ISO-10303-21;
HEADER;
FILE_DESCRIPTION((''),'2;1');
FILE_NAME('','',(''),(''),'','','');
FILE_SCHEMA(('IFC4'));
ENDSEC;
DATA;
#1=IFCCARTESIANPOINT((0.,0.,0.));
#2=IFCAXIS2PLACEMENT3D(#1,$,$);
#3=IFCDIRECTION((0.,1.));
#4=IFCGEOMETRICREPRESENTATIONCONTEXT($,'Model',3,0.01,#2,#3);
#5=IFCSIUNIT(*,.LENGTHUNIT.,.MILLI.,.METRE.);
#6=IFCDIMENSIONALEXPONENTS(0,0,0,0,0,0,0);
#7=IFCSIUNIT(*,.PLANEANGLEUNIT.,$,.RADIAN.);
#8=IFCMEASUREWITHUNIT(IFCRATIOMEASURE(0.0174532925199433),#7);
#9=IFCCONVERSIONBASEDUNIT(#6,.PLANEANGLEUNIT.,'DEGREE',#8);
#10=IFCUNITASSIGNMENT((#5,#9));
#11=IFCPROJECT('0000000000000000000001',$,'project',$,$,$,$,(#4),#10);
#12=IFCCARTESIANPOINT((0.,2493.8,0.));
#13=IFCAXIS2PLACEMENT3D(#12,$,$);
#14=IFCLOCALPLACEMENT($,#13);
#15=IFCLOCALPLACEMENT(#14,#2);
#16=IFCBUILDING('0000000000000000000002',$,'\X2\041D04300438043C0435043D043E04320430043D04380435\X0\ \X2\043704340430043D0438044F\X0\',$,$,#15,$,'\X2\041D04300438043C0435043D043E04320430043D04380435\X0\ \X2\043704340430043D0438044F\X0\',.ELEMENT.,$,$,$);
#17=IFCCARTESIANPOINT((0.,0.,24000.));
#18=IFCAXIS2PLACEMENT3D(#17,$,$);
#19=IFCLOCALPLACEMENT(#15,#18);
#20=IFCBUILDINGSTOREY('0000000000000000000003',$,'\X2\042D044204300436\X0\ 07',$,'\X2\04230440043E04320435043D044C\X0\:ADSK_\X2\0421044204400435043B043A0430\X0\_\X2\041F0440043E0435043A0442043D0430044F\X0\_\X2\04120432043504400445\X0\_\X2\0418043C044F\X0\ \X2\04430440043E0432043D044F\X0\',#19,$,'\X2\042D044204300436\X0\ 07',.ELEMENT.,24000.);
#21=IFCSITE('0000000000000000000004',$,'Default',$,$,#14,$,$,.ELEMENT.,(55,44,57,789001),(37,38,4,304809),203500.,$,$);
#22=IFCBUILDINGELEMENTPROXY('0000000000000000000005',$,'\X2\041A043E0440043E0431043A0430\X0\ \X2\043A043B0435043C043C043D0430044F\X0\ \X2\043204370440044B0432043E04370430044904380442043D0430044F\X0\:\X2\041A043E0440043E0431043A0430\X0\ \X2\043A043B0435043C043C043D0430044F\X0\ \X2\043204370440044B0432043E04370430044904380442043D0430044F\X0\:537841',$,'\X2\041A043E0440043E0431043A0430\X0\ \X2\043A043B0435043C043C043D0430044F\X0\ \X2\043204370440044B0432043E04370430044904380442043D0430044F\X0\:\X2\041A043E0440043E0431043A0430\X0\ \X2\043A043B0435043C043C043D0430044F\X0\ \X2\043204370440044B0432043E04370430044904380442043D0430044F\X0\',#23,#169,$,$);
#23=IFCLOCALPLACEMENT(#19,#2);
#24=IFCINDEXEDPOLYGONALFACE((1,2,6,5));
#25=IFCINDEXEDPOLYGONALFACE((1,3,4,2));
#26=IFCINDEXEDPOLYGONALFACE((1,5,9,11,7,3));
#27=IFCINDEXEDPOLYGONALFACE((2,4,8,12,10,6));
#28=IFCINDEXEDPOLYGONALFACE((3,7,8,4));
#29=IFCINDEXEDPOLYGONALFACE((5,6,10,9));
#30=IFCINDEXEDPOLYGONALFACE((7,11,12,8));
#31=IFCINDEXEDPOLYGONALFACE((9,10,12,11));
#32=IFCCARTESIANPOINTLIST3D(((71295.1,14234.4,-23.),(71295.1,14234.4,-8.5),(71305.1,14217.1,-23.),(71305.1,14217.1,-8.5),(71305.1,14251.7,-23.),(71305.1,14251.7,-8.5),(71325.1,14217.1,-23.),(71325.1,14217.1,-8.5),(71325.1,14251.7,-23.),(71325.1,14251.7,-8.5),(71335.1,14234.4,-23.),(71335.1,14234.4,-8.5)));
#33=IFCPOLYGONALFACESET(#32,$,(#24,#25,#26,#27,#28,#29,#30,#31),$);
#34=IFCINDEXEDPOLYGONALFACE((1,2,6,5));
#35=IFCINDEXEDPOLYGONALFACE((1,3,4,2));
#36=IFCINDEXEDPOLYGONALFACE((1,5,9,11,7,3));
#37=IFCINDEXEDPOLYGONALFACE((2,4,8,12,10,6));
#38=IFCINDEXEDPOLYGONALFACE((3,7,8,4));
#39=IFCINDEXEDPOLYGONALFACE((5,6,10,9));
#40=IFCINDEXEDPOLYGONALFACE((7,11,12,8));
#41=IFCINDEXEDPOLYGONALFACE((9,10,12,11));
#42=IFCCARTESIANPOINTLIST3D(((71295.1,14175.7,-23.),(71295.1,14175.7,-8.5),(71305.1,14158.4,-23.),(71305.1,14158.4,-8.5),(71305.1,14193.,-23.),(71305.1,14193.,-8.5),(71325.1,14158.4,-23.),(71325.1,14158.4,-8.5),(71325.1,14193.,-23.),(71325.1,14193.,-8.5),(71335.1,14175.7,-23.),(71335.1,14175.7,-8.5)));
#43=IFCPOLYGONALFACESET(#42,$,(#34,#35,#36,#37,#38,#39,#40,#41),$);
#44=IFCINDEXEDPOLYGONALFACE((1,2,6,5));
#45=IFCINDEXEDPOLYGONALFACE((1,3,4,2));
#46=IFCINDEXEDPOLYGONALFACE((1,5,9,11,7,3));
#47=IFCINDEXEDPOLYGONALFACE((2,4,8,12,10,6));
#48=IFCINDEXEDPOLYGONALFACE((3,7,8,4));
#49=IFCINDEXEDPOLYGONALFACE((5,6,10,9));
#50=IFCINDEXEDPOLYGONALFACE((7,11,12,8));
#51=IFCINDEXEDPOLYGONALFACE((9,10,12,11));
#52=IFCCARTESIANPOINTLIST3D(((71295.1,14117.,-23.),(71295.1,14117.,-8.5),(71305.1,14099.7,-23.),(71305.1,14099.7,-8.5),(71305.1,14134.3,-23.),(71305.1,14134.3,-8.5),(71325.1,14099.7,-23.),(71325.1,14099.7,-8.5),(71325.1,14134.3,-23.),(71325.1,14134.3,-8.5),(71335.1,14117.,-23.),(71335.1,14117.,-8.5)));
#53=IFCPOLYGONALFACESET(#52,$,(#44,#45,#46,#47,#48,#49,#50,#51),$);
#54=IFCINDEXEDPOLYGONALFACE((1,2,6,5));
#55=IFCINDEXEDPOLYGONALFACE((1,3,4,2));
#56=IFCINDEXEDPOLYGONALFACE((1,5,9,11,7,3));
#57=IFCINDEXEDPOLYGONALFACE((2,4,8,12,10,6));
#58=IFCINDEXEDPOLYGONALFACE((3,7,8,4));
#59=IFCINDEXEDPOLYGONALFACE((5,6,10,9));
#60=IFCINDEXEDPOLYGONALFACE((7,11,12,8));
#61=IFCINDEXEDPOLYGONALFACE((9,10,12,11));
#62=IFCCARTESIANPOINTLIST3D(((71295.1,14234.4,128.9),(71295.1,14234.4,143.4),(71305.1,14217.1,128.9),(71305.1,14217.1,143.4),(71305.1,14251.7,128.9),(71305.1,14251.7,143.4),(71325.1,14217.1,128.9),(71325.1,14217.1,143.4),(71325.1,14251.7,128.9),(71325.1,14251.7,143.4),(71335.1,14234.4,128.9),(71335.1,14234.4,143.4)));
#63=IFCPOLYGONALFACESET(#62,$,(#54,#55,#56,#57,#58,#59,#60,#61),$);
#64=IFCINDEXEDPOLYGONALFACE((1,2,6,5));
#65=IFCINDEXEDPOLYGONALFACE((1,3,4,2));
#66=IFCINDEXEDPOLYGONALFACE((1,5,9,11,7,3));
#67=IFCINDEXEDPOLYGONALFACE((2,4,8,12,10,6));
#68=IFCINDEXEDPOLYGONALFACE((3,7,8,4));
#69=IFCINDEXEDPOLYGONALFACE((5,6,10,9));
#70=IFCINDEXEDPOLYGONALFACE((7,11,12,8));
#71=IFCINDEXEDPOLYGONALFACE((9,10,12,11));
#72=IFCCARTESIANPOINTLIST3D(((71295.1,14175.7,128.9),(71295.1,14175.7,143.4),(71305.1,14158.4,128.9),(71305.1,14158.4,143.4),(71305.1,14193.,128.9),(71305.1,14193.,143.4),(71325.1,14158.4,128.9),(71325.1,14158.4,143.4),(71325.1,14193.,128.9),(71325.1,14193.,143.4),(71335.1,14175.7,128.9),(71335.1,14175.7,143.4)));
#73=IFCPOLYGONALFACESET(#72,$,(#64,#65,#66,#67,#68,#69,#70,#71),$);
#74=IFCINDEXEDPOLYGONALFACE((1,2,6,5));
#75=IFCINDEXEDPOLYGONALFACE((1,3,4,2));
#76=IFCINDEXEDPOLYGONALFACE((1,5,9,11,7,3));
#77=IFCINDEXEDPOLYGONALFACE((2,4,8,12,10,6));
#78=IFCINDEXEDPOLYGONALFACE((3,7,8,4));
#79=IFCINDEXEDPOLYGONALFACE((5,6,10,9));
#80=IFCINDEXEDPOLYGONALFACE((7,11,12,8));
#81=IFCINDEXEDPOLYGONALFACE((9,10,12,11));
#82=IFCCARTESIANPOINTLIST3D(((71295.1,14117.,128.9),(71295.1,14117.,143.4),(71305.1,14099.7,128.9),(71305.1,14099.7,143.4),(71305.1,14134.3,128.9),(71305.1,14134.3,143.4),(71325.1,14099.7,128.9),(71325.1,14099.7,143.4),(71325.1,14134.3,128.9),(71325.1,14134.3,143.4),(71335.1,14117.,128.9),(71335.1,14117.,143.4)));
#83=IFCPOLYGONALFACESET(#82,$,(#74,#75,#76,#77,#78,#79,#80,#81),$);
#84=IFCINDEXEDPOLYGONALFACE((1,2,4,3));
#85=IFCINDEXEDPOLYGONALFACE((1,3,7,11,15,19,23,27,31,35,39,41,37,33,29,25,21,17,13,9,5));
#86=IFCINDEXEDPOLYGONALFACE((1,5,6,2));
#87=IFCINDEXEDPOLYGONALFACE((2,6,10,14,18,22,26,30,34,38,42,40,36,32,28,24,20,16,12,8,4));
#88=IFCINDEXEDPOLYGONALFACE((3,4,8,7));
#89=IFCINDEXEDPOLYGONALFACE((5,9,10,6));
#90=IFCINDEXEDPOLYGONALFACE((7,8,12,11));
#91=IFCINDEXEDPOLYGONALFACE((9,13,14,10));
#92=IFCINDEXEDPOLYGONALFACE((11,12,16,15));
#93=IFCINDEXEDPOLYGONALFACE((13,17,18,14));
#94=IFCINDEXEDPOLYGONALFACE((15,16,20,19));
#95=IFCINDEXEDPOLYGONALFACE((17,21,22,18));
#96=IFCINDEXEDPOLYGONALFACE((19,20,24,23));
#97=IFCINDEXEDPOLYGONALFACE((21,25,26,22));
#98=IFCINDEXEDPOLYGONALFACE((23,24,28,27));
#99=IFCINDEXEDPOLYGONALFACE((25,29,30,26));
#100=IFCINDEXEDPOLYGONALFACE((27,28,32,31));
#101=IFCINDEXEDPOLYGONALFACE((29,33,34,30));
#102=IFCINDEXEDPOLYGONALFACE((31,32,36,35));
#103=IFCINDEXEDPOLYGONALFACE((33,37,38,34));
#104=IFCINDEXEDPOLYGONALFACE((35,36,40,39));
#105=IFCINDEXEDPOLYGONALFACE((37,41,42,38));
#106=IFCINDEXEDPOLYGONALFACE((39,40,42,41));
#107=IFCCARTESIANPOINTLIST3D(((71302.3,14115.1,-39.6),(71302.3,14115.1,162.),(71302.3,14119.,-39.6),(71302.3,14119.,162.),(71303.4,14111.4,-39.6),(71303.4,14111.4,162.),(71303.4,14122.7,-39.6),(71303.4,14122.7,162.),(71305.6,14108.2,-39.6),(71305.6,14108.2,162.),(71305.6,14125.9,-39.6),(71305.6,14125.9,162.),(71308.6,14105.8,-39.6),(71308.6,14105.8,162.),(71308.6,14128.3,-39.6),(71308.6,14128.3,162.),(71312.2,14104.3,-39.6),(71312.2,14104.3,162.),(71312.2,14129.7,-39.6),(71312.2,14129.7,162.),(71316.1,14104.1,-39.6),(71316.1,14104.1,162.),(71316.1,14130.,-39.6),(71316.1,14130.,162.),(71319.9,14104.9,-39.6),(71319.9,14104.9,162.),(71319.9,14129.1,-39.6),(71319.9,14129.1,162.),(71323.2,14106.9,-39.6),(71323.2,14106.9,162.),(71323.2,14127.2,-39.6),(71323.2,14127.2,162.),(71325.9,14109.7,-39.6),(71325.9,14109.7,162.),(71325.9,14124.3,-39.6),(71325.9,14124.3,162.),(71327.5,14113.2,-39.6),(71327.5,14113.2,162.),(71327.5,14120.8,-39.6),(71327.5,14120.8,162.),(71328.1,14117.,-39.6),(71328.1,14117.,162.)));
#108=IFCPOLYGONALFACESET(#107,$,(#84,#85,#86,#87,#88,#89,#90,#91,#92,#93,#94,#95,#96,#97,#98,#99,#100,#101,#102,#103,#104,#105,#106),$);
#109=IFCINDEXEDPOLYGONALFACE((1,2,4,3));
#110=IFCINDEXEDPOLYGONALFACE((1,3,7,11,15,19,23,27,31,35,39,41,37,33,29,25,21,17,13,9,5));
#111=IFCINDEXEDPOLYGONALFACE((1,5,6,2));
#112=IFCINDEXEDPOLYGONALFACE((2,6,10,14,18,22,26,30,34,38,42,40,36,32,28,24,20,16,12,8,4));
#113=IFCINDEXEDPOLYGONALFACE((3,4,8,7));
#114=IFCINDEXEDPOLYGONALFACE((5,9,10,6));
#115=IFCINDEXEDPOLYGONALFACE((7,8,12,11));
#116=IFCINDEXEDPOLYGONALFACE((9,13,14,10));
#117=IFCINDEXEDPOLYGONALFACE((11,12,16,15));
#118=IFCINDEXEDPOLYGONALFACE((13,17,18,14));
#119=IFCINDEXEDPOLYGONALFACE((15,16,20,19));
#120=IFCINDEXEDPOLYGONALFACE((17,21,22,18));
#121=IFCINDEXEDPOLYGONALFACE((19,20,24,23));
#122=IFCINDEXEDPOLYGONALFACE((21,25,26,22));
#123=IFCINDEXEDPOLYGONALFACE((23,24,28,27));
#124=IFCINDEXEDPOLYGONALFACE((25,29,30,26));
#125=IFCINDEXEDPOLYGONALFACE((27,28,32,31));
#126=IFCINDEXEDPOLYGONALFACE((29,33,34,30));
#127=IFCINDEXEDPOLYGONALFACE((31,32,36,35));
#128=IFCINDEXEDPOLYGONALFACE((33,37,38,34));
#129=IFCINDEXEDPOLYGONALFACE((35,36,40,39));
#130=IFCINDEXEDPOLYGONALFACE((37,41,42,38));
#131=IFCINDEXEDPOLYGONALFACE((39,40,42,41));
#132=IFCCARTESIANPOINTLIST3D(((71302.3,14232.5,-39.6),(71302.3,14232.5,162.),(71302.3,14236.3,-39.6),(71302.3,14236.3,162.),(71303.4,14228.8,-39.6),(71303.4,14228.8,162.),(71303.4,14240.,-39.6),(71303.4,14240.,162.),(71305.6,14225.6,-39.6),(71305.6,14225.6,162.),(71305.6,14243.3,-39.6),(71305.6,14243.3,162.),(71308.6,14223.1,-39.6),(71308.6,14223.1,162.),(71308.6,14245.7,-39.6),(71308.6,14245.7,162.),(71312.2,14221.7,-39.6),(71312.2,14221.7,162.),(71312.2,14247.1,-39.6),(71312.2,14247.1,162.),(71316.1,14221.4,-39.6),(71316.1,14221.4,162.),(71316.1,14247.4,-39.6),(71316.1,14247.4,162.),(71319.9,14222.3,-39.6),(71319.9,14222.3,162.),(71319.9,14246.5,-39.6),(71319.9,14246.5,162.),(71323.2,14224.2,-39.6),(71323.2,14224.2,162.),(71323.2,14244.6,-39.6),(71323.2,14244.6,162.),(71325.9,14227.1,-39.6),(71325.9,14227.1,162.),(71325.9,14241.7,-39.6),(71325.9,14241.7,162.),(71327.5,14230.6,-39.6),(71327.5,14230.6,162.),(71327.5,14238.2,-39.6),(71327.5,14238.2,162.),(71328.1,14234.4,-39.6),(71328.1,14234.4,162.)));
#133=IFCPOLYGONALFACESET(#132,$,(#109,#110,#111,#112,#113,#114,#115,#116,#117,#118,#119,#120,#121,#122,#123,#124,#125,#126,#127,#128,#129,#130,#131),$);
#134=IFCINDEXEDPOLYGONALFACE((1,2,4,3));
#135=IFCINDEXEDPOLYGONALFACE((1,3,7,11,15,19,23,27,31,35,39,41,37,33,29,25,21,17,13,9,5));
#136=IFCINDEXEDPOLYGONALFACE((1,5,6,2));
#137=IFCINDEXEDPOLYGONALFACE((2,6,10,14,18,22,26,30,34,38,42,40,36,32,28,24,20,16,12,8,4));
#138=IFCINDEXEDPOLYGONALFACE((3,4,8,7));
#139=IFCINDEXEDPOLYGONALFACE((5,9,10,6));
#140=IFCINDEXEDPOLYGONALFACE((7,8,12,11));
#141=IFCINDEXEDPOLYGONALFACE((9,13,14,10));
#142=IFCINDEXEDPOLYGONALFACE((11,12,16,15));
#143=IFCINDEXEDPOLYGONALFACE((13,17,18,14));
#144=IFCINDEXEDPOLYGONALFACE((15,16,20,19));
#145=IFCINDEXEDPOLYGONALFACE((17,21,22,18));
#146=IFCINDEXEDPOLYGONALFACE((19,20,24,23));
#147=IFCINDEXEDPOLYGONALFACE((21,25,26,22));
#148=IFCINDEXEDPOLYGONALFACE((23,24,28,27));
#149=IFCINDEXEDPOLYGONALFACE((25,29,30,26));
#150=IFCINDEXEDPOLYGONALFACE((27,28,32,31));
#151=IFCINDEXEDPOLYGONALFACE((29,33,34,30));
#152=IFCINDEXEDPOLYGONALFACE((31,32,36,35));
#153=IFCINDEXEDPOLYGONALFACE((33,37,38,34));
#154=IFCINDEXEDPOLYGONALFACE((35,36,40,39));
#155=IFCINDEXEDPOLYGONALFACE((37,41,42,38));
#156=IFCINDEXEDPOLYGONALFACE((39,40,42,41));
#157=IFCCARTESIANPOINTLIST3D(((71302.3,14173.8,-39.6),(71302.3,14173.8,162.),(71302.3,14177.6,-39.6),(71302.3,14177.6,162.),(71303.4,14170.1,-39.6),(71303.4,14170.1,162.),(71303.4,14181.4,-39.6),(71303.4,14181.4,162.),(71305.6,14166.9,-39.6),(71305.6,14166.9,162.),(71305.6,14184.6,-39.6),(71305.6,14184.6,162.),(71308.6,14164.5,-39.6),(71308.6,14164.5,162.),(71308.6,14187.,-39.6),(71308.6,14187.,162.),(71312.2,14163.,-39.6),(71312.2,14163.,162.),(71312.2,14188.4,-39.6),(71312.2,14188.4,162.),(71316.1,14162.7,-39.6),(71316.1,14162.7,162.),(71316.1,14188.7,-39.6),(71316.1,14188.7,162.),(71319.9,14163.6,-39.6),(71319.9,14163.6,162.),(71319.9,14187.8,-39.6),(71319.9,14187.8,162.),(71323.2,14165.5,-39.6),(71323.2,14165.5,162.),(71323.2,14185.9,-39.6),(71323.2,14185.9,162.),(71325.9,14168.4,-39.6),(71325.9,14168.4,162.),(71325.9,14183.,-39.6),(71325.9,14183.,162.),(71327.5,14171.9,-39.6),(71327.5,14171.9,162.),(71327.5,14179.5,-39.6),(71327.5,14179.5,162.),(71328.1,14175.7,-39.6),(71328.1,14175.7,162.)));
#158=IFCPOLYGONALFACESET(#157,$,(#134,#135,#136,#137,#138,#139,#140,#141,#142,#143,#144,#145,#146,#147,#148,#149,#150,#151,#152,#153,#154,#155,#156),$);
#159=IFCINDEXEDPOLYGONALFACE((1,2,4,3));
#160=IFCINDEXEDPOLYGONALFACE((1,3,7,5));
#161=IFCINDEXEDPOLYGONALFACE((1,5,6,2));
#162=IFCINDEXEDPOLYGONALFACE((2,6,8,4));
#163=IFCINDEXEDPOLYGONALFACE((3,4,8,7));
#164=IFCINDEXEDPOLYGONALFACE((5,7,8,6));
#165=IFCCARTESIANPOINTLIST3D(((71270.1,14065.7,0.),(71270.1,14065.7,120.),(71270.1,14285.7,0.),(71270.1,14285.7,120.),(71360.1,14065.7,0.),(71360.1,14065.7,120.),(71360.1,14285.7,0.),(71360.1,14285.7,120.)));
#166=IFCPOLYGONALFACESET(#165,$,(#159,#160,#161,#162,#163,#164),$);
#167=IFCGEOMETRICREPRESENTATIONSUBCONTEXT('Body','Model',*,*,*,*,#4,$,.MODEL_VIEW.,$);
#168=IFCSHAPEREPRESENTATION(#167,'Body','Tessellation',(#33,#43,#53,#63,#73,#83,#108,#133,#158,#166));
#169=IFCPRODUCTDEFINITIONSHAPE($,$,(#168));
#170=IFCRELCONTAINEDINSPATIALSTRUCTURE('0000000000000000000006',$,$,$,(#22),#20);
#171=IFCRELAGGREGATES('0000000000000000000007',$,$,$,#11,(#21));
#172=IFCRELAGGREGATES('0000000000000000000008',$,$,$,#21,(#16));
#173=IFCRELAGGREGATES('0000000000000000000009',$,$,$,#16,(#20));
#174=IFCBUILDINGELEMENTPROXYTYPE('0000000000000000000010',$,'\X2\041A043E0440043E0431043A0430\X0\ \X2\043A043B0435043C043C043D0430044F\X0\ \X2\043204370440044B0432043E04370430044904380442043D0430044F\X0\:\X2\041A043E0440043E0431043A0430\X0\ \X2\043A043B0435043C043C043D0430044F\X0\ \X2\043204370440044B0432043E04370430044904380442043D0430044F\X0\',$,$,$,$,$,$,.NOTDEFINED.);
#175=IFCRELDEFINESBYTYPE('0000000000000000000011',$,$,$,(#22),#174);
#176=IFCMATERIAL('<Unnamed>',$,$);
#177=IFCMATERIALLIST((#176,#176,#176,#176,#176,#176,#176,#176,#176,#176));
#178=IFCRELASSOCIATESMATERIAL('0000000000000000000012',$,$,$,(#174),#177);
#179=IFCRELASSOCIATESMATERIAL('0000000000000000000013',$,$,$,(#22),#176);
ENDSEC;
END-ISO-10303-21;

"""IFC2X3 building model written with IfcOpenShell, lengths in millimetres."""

from ifc_helpers import new_model, entity, si_unit, converted_unit, direction, frame, frame_2d, origin, place, context, subcontext, project, spatial, polyline, rectangle, circle, outline, extrude, source, transform, mapped, material, material_list, type_object, type_shapes, element, save


model = new_model("IFC2X3")

# Units and contexts
model_context = context("Model", 3, precision=0.01, world=origin(), true_north=direction((0.0, 1.0)))
body_context = subcontext(model_context, "Body", "Model", "MODEL_VIEW")
ifc_project = project(units=[si_unit("LENGTHUNIT", "METRE", prefix="MILLI"), converted_unit("PLANEANGLEUNIT", "DEGREE", entity("IfcRatioMeasure", 0.0174532925199433), si_unit("PLANEANGLEUNIT", "RADIAN"), dimensions=[0, 0, 0, 0, 0, 0, 0])], contexts=[model_context])

# Site, building, storey
site_placement = place(None, frame((0.0, 2493.8, 0.0)))
site = spatial("IfcSite", under=ifc_project, at=site_placement, Name="Default", CompositionType="ELEMENT", RefLatitude=(55, 44, 57, 789001), RefLongitude=(37, 38, 4, 304809), RefElevation=203500.0)
building_placement = place(site_placement, origin())
building = spatial("IfcBuilding", under=site, at=building_placement, Name="Наименование здания", LongName="Наименование здания", CompositionType="ELEMENT")
storey_placement = place(building_placement, frame((0.0, 0.0, 24000.0)))
storey = spatial("IfcBuildingStorey", under=building, at=storey_placement, Name="Этаж 07", ObjectType="Уровень:ADSK_Стрелка_Проектная_Вверх_Имя уровня", LongName="Этаж 07", CompositionType="ELEMENT", Elevation=24000.0)

# Building element proxy
ifc_material = material(Name="<Unnamed>")
ifc_material_list = material_list([ifc_material, ifc_material, ifc_material, ifc_material, ifc_material, ifc_material, ifc_material, ifc_material, ifc_material, ifc_material])
building_element_proxy_type = type_object("IfcBuildingElementProxyType", Name="Коробка клеммная взрывозащитная:Коробка клеммная взрывозащитная", PredefinedType="NOTDEFINED", material=ifc_material_list)
shared_shape = source(origin(), body_context, "Body", "SweptSolid", [
    extrude(outline(polyline([(-10.0, -17.3), (10.0, -17.3), (20.0, 0.0), (10.0, 17.3), (-10.0, 17.3), (-20.0, 0.0), (-10.0, -17.3)])), frame((0.0, 58.7, -23.0), z_axis=(0.0, 0.0, 1.0), x_axis=(-1.0, 0.0, 0.0)), (0.0, 0.0, 1.0), 14.4),
    extrude(outline(polyline([(-10.0, -17.3), (10.0, -17.3), (20.0, 0.0), (10.0, 17.3), (-10.0, 17.3), (-20.0, 0.0), (-10.0, -17.3)])), frame((0.0, 0.0, -23.0), z_axis=(0.0, 0.0, 1.0), x_axis=(-1.0, 0.0, 0.0)), (0.0, 0.0, 1.0), 14.4),
    extrude(outline(polyline([(-10.0, -17.3), (10.0, -17.3), (20.0, 0.0), (10.0, 17.3), (-10.0, 17.3), (-20.0, 0.0), (-10.0, -17.3)])), frame((0.0, -58.7, -23.0), z_axis=(0.0, 0.0, 1.0), x_axis=(-1.0, 0.0, 0.0)), (0.0, 0.0, 1.0), 14.4),
    extrude(outline(polyline([(-10.0, -17.3), (10.0, -17.3), (20.0, 0.0), (10.0, 17.3), (-10.0, 17.3), (-20.0, 0.0), (-10.0, -17.3)])), frame((0.0, 58.7, 128.9), z_axis=(0.0, 0.0, 1.0), x_axis=(-1.0, 0.0, 0.0)), (0.0, 0.0, 1.0), 14.4),
    extrude(outline(polyline([(-10.0, -17.3), (10.0, -17.3), (20.0, 0.0), (10.0, 17.3), (-10.0, 17.3), (-20.0, 0.0), (-10.0, -17.3)])), frame((0.0, 0.0, 128.9), z_axis=(0.0, 0.0, 1.0), x_axis=(-1.0, 0.0, 0.0)), (0.0, 0.0, 1.0), 14.4),
    extrude(outline(polyline([(-10.0, -17.3), (10.0, -17.3), (20.0, 0.0), (10.0, 17.3), (-10.0, 17.3), (-20.0, 0.0), (-10.0, -17.3)])), frame((0.0, -58.7, 128.9), z_axis=(0.0, 0.0, 1.0), x_axis=(-1.0, 0.0, 0.0)), (0.0, 0.0, 1.0), 14.4),
    extrude(circle(Radius=13.0, at=frame_2d((0.0, 0.0), x_axis=(1.0, 0.0))), frame((0.0, -58.7, -39.6)), (0.0, 0.0, 1.0), 201.6),
    extrude(circle(Radius=13.0, at=frame_2d((0.0, 0.0), x_axis=(1.0, 0.0))), frame((0.0, 58.7, -39.6)), (0.0, 0.0, 1.0), 201.6),
    extrude(circle(Radius=13.0, at=frame_2d((0.0, 0.0), x_axis=(1.0, 0.0))), frame((0.0, 0.0, -39.6)), (0.0, 0.0, 1.0), 201.6),
    extrude(rectangle(XDim=220.0, YDim=90.0, at=frame_2d((0.0, 0.0), x_axis=(1.0, 0.0))), frame((0.0, 0.0, 0.0), z_axis=(0.0, 0.0, 1.0), x_axis=(0.0, -1.0, 0.0)), (0.0, 0.0, 1.0), 120.0),
])
type_shapes(building_element_proxy_type, [shared_shape])
for number, where, name in (
    (1, (71315.1, 14175.7, 0.0), "Коробка клеммная взрывозащитная:Коробка клеммная взрывозащитная:537841"),
):
    element("IfcBuildingElementProxy", number, at=place(storey_placement, frame(where)), inside=storey, type_object=building_element_proxy_type, material=ifc_material, Name=name, ObjectType="Коробка клеммная взрывозащитная:Коробка клеммная взрывозащитная", context=body_context, shape_type="MappedRepresentation", body=[
        mapped(shared_shape, transform((0.0, 0.0, 0.0), scale=1.0)),
    ])

save(model, "model.ifc")
